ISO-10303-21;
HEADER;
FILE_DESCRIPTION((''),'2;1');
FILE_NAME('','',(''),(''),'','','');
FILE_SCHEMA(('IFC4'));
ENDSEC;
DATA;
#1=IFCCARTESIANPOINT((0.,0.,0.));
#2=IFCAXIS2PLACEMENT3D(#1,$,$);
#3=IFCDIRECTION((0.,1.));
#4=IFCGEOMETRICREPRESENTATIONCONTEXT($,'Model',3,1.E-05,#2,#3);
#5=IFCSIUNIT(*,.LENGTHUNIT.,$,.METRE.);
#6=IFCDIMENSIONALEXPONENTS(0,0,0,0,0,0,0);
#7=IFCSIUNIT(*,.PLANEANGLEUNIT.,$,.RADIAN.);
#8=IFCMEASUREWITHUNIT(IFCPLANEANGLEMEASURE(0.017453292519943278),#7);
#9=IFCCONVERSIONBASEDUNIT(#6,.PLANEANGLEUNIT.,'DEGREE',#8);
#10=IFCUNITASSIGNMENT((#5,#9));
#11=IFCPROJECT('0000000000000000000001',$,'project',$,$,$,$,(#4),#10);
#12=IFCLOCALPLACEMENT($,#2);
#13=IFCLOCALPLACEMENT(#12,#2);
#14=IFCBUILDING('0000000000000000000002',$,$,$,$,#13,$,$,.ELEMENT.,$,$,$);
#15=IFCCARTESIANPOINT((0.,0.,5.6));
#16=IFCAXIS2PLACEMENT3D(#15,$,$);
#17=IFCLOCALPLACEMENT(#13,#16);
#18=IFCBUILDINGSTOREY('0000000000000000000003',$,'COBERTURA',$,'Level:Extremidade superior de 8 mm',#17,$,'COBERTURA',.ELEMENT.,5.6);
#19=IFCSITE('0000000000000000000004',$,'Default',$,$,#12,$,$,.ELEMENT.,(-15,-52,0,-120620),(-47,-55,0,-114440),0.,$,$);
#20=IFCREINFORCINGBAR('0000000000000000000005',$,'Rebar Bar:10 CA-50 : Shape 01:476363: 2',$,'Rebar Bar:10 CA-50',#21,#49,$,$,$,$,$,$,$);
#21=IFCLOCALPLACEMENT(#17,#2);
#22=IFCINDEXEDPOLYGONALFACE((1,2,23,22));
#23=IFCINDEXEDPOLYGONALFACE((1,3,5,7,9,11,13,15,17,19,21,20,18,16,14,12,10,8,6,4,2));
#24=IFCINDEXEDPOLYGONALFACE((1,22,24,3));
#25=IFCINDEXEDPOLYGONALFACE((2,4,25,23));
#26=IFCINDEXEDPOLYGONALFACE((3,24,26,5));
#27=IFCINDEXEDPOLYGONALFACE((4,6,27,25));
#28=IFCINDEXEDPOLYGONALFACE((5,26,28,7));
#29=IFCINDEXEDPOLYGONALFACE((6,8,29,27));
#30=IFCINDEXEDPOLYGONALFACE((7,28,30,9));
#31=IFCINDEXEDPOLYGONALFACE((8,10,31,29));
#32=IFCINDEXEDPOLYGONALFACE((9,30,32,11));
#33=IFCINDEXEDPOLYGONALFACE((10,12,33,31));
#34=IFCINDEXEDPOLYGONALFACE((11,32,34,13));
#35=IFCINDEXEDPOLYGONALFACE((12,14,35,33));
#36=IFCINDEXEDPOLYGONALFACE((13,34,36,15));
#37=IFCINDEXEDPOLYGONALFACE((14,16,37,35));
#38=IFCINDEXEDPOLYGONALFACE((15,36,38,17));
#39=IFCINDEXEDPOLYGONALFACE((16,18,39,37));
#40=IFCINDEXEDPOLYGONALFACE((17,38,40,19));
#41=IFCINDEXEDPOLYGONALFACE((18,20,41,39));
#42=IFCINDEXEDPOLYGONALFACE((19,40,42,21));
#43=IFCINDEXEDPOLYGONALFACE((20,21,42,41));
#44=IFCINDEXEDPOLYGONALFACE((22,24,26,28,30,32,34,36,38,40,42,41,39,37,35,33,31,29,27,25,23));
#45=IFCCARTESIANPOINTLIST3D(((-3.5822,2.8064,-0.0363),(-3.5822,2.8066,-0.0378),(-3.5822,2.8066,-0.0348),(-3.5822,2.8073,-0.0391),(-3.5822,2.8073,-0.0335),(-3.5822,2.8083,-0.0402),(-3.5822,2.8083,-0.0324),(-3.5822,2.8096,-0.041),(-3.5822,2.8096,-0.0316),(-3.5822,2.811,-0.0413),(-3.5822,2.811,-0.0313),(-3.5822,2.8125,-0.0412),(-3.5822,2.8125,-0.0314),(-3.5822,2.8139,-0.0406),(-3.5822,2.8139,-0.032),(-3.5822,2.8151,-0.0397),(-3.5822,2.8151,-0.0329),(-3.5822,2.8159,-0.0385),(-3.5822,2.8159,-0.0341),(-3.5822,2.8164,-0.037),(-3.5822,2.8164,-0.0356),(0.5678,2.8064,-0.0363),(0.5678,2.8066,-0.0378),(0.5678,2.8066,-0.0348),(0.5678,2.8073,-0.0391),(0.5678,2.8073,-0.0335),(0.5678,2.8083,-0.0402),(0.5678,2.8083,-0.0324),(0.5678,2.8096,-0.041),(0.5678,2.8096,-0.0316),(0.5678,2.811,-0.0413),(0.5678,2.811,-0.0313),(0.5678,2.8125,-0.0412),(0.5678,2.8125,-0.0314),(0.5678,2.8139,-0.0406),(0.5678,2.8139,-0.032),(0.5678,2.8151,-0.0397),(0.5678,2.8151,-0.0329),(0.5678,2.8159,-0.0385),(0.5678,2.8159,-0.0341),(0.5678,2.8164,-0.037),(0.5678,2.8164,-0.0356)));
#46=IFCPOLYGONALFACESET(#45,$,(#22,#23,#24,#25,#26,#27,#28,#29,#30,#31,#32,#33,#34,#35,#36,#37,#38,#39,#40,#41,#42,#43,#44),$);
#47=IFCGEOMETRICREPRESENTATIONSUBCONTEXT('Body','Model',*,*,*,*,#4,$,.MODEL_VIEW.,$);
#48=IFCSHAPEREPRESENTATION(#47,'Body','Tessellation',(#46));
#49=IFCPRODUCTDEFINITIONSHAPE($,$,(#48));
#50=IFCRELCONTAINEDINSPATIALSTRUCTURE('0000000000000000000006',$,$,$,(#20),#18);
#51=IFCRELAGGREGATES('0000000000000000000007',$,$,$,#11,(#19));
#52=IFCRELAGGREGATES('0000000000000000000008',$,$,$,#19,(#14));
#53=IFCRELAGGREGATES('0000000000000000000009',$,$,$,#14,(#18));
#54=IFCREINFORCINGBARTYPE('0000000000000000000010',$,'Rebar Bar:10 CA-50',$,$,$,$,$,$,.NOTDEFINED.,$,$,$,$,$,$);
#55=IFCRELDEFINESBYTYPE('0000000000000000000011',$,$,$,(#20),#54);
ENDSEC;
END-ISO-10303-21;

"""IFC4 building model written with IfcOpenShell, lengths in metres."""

from ifc_helpers import new_model, entity, si_unit, converted_unit, direction, frame, origin, place, context, subcontext, project, spatial, type_object, element, save


model = new_model("IFC4")

# Units and contexts
model_context = context("Model", 3, precision=1e-05, world=origin(), true_north=direction((0.0, 1.0)))
body_context = subcontext(model_context, "Body", "Model", "MODEL_VIEW")
ifc_project = project(units=[si_unit("LENGTHUNIT", "METRE"), converted_unit("PLANEANGLEUNIT", "DEGREE", entity("IfcPlaneAngleMeasure", 0.017453292519943278), si_unit("PLANEANGLEUNIT", "RADIAN"), dimensions=[0, 0, 0, 0, 0, 0, 0])], contexts=[model_context])

# Site, building, storey
site_placement = place(None, origin())
site = spatial("IfcSite", under=ifc_project, at=site_placement, Name="Default", CompositionType="ELEMENT", RefLatitude=(-15, -52, 0, -120620), RefLongitude=(-47, -55, 0, -114440), RefElevation=0.0)
building_placement = place(site_placement, origin())
building = spatial("IfcBuilding", under=site, at=building_placement, CompositionType="ELEMENT")
storey_placement = place(building_placement, frame((0.0, 0.0, 5.6)))
storey = spatial("IfcBuildingStorey", under=building, at=storey_placement, Name="COBERTURA", ObjectType="Level:Extremidade superior de 8 mm", LongName="COBERTURA", CompositionType="ELEMENT", Elevation=5.6)

# Reinforcing bar
reinforcing_bar_type = type_object("IfcReinforcingBarType", Name="Rebar Bar:10 CA-50", PredefinedType="NOTDEFINED")
reinforcing_bar_1_placement = place(storey_placement, origin())
element("IfcReinforcingBar", 1, at=reinforcing_bar_1_placement, inside=storey, type_object=reinforcing_bar_type, Name="Rebar Bar:10 CA-50 : Shape 01:476363: 2", ObjectType="Rebar Bar:10 CA-50", context=body_context, shape_type="AdvancedSweptSolid", body=[
    entity("IfcSweptDiskSolid", entity("IfcIndexedPolyCurve", entity("IfcCartesianPointList3D", [[0.5678, 2.8114, -0.0363], [-3.5822, 2.8114, -0.0363]]), None, False), 0.005, None, 0.0, 1.0),
])

save(model, "model.ifc")
